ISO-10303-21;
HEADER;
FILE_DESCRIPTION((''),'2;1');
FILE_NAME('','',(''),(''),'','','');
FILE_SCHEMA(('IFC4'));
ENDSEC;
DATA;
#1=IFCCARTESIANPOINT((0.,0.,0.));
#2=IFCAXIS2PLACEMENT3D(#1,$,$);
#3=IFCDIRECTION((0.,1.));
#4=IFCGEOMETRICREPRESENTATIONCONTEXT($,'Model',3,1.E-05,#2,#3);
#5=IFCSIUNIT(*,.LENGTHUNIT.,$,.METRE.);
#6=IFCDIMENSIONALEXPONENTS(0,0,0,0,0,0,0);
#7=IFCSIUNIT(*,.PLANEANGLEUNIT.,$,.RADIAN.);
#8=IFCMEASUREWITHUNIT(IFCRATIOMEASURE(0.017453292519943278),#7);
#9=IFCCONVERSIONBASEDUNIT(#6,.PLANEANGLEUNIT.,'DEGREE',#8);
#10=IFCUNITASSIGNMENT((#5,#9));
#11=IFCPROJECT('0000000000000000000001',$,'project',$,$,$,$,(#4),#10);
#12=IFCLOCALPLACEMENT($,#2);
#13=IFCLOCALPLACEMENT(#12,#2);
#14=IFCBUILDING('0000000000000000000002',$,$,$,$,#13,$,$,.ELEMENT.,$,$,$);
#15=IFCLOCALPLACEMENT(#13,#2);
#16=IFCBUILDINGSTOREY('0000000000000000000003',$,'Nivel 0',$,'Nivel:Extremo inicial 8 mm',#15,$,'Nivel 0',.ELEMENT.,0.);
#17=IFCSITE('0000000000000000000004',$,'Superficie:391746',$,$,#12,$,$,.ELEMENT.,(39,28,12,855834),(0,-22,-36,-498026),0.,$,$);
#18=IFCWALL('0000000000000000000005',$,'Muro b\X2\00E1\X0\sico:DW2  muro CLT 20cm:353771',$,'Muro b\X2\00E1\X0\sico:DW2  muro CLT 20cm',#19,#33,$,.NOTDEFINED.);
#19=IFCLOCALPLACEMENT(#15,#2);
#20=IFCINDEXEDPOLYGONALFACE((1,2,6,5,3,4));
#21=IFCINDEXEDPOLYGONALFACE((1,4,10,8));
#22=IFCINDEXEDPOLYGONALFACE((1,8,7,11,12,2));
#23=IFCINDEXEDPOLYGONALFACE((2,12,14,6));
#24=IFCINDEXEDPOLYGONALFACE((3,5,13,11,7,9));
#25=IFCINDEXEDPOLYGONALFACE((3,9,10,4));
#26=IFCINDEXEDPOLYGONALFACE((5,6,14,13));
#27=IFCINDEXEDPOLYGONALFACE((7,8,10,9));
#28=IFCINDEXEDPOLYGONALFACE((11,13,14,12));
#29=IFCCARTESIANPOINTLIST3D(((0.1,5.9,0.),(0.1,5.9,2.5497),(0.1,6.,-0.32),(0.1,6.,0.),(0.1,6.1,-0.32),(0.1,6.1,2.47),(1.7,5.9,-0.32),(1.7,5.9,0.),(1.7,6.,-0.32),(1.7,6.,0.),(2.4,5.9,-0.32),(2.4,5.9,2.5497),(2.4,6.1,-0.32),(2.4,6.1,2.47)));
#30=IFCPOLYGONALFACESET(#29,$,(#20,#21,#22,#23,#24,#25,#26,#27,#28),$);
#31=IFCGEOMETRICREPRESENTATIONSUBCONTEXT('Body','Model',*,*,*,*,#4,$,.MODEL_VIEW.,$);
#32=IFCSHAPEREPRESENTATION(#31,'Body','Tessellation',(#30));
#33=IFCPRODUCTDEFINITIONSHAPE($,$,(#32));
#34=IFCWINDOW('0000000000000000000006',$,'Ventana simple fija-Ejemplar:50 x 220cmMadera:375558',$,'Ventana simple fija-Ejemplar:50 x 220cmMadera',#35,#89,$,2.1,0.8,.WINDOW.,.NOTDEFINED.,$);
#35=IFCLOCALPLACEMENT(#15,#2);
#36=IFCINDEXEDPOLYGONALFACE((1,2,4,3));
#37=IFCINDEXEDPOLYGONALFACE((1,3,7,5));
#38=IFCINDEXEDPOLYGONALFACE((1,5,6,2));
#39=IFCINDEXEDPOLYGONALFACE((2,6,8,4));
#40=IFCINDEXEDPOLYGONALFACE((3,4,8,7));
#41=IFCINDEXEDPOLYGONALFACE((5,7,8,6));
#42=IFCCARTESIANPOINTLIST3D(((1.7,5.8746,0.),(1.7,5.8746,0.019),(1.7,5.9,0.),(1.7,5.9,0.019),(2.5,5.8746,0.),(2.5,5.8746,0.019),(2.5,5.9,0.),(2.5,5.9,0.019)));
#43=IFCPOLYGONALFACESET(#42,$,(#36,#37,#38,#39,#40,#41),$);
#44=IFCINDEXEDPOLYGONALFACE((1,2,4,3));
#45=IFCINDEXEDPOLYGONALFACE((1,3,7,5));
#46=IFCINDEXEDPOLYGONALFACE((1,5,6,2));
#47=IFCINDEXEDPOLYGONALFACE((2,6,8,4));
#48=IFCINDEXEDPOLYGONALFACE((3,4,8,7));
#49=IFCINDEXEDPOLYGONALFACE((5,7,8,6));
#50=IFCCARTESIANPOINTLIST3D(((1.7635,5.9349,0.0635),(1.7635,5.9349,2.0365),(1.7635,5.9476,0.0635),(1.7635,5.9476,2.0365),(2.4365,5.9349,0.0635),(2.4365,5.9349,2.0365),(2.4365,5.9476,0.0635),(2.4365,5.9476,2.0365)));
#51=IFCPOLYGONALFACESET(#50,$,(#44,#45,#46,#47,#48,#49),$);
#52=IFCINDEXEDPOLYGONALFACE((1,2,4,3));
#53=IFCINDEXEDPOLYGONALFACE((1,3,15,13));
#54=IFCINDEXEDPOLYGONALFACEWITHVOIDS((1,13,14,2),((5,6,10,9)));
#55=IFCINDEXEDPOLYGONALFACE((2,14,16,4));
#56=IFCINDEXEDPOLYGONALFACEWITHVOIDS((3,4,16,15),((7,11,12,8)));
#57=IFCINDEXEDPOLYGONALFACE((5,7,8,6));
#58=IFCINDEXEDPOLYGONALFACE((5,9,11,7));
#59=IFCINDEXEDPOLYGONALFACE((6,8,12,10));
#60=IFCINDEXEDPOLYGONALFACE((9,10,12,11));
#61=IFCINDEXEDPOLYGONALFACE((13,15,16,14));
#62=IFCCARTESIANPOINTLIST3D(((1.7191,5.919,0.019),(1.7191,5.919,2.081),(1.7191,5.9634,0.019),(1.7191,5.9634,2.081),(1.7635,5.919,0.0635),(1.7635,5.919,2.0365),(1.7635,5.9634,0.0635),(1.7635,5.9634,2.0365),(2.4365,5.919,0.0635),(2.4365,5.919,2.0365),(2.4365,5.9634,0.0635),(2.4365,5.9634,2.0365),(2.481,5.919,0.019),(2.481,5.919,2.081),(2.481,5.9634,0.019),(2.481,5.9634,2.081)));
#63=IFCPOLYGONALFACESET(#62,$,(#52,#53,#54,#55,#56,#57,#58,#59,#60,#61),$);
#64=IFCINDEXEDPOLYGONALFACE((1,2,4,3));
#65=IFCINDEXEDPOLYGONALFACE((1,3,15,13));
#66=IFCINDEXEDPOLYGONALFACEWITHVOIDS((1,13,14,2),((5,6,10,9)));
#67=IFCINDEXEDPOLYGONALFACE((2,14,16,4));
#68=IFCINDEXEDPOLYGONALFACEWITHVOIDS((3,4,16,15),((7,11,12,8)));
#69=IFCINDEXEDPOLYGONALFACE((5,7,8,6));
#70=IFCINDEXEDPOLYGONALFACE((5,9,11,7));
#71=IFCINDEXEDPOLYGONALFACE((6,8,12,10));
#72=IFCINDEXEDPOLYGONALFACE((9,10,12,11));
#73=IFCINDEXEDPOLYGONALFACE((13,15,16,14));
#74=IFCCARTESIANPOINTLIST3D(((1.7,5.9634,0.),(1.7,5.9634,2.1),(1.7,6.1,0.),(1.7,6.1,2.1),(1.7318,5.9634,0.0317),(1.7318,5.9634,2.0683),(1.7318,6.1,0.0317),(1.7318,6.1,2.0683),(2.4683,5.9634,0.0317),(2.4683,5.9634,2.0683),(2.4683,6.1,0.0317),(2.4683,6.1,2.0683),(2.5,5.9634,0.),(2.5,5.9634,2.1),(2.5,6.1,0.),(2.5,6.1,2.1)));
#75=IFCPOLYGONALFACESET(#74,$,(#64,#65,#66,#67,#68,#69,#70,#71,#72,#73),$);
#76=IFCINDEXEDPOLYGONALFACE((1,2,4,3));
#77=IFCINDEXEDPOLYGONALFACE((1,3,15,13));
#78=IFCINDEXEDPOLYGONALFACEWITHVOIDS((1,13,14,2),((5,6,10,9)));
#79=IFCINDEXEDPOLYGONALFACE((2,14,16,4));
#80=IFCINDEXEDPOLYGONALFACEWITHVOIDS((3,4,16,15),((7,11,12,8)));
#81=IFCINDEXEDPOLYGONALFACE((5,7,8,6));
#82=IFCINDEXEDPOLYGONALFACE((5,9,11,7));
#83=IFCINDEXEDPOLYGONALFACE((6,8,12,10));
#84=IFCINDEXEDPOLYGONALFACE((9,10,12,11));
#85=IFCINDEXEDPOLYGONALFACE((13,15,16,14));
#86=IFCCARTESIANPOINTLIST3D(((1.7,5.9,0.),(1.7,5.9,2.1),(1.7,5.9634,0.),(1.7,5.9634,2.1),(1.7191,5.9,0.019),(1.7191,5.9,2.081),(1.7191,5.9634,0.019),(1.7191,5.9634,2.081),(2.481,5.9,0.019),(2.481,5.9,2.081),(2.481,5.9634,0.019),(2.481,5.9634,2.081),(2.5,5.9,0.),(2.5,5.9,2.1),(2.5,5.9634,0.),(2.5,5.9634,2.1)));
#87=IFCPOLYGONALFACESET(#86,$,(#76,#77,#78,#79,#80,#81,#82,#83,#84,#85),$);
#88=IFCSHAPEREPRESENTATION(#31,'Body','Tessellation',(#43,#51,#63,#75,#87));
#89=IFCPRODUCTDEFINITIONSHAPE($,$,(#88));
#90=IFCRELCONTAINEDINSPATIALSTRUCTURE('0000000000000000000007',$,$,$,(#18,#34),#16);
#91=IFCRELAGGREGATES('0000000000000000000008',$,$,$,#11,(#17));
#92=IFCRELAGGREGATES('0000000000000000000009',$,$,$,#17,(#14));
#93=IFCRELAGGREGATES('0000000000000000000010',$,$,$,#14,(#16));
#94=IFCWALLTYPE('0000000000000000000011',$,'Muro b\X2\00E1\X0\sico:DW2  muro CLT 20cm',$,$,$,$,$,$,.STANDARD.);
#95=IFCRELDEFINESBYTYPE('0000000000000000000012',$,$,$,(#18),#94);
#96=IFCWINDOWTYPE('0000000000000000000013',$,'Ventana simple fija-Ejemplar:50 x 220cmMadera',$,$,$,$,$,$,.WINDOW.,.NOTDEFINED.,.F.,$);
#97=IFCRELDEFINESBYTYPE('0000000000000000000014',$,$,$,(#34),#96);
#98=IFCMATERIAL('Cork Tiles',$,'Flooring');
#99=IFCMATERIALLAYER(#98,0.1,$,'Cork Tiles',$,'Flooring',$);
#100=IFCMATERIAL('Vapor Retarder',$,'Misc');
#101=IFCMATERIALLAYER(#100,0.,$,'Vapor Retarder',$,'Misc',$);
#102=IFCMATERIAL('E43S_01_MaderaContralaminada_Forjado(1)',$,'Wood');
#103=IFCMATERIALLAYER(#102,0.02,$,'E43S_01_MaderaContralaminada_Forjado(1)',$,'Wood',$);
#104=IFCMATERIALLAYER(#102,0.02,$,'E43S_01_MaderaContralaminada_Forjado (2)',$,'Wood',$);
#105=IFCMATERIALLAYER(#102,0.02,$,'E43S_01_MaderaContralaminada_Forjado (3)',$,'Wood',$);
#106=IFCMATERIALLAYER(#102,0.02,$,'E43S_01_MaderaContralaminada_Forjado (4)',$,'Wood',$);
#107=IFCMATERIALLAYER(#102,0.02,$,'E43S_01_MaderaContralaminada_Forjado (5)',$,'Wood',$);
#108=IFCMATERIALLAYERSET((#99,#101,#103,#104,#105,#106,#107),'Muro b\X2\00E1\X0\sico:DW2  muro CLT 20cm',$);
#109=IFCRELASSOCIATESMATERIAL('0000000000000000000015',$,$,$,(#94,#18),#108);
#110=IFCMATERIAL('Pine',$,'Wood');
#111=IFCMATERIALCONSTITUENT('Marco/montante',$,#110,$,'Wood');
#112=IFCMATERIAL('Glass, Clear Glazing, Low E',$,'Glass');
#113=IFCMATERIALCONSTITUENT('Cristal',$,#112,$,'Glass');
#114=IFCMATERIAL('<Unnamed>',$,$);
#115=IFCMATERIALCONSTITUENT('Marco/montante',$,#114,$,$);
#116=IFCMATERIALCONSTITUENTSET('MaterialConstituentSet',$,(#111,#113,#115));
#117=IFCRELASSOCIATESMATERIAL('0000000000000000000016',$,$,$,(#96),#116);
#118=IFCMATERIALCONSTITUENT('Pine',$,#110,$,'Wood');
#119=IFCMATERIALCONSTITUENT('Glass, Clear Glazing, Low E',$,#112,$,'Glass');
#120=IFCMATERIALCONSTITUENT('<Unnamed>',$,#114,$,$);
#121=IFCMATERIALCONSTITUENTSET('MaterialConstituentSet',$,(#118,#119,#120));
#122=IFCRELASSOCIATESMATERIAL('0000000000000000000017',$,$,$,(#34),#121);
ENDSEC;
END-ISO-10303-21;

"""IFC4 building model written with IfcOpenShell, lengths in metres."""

from ifc_helpers import new_model, entity, si_unit, converted_unit, direction, frame, frame_2d, origin, origin_2d_with_axis, place, context, subcontext, project, spatial, polyline, rectangle, outline, extrude, clip, bounded_halfspace, source, transform, mapped, material, layer, layer_set, layer_usage, constituent, constituent_set, type_object, type_shapes, element, fill, save


model = new_model("IFC4")

# Units and contexts
model_context = context("Model", 3, precision=1e-05, world=origin(), true_north=direction((0.0, 1.0)))
body_context = subcontext(model_context, "Body", "Model", "MODEL_VIEW")
ifc_project = project(units=[si_unit("LENGTHUNIT", "METRE"), converted_unit("PLANEANGLEUNIT", "DEGREE", entity("IfcRatioMeasure", 0.017453292519943278), si_unit("PLANEANGLEUNIT", "RADIAN"), dimensions=[0, 0, 0, 0, 0, 0, 0])], contexts=[model_context])

# Site, building, storey
site_placement = place(None, origin())
site = spatial("IfcSite", under=ifc_project, at=site_placement, Name="Superficie:391746", CompositionType="ELEMENT", RefLatitude=(39, 28, 12, 855834), RefLongitude=(0, -22, -36, -498026), RefElevation=0.0)
building_placement = place(site_placement, origin())
building = spatial("IfcBuilding", under=site, at=building_placement, CompositionType="ELEMENT")
storey_placement = place(building_placement, origin())
storey = spatial("IfcBuildingStorey", under=building, at=storey_placement, Name="Nivel 0", ObjectType="Nivel:Extremo inicial 8 mm", LongName="Nivel 0", CompositionType="ELEMENT", Elevation=0.0)

# Shared definitions
ifc_material_1 = material(Name="E43S_01_MaderaContralaminada_Forjado(1)", Category="Wood")

# Shared definitions
ifc_material_2 = material(Name="Cork Tiles", Category="Flooring")

# Shared definitions
ifc_material_3 = material(Name="Vapor Retarder", Category="Misc")

# Wall, opening, window
ifc_layer_1 = layer(ifc_material_2, 0.1, Name="Cork Tiles", Category="Flooring")
ifc_layer_2 = layer(ifc_material_3, 0.0, Name="Vapor Retarder", Category="Misc")
ifc_layer_3 = layer(ifc_material_1, 0.02, Name="E43S_01_MaderaContralaminada_Forjado(1)", Category="Wood")
ifc_layer_4 = layer(ifc_material_1, 0.02, Name="E43S_01_MaderaContralaminada_Forjado (2)", Category="Wood")
ifc_layer_5 = layer(ifc_material_1, 0.02, Name="E43S_01_MaderaContralaminada_Forjado (3)", Category="Wood")
ifc_layer_6 = layer(ifc_material_1, 0.02, Name="E43S_01_MaderaContralaminada_Forjado (4)", Category="Wood")
ifc_layer_7 = layer(ifc_material_1, 0.02, Name="E43S_01_MaderaContralaminada_Forjado (5)", Category="Wood")
ifc_layer_set_1 = layer_set([ifc_layer_1, ifc_layer_2, ifc_layer_3, ifc_layer_4, ifc_layer_5, ifc_layer_6, ifc_layer_7], Name="Muro básico:DW2  muro CLT 20cm")
ifc_layer_usage_1 = layer_usage(ifc_layer_set_1, "AXIS2", "NEGATIVE", 0.1)
wall_type_1 = type_object("IfcWallType", Name="Muro básico:DW2  muro CLT 20cm", PredefinedType="STANDARD", material=ifc_layer_set_1)
wall_1_placement = place(storey_placement, frame((0.1, 6.0, -0.32)))
wall_1 = element("IfcWall", 1, at=wall_1_placement, inside=storey, type_object=wall_type_1, material=ifc_layer_usage_1, Name="Muro básico:DW2  muro CLT 20cm:353771", ObjectType="Muro básico:DW2  muro CLT 20cm", PredefinedType="NOTDEFINED", context=body_context, shape_type="Clipping", body=[
    clip(clip(extrude(rectangle(XDim=0.2, YDim=2.3, at=frame_2d((1.15, 0.0), x_axis=(0.0, -1.0))), origin(), (0.0, 0.0, 1.0), 2.8697), bounded_halfspace(frame((0.0, 0.1, 2.79), z_axis=(0.0, 0.370288, 0.928917), x_axis=(-1.0, 0.0, 0.0)), False, frame((0.0, 0.1, 2.79)), polyline([(0.0, 0.0), (0.0, -0.2), (2.3, -0.2), (2.3, 0.0), (0.0, 0.0)]))), bounded_halfspace(frame((0.0, -0.1, 0.32), z_axis=(0.0, 0.0, -1.0), x_axis=(0.0, 1.0, 0.0)), False, frame((0.0, -0.1, 0.32)), polyline([(0.0, 0.0), (1.6, 0.0), (1.6, 0.1), (0.0, 0.1), (0.0, 0.0)]))),
])
opening_1_placement = place(wall_1_placement, frame((2.4, 0.1, 0.32)))
opening_1 = element("IfcOpeningElement", 2, at=opening_1_placement, cuts=wall_1, PredefinedType="OPENING", context=body_context, shape_type="SweptSolid", body=[
    extrude(rectangle(XDim=2.1, YDim=0.8, at=frame_2d((1.05, 0.4), x_axis=(-1.0, 0.0))), frame((0.0, 0.0, 0.0), z_axis=(0.0, -1.0, 0.0), x_axis=(0.0, 0.0, 1.0)), (0.0, 0.0, 1.0), 0.2),
])
ifc_material_4 = material(Name="Pine", Category="Wood")
ifc_constituent_1 = constituent(ifc_material_4, Name="Pine", Category="Wood")
ifc_material_5 = material(Name="Glass, Clear Glazing, Low E", Category="Glass")
ifc_constituent_2 = constituent(ifc_material_5, Name="Glass, Clear Glazing, Low E", Category="Glass")
ifc_material_6 = material(Name="<Unnamed>")
ifc_constituent_3 = constituent(ifc_material_6, Name="<Unnamed>")
ifc_constituent_set_1 = constituent_set(constituents=[ifc_constituent_1, ifc_constituent_2, ifc_constituent_3], Name="MaterialConstituentSet")
ifc_constituent_4 = constituent(ifc_material_4, Name="Marco/montante", Category="Wood")
ifc_constituent_5 = constituent(ifc_material_5, Name="Cristal", Category="Glass")
ifc_constituent_6 = constituent(ifc_material_6, Name="Marco/montante")
ifc_constituent_set_2 = constituent_set(constituents=[ifc_constituent_4, ifc_constituent_5, ifc_constituent_6], Name="MaterialConstituentSet")
window_type_1 = type_object("IfcWindowType", Name="Ventana simple fija-Ejemplar:50 x 220cmMadera", ParameterTakesPrecedence=False, PartitioningType="NOTDEFINED", PredefinedType="WINDOW", material=ifc_constituent_set_2)
shared_shape_1 = source(origin(), body_context, "Body", "SweptSolid", [
    extrude(rectangle(XDim=0.8, YDim=0.0254, at=origin_2d_with_axis()), frame((0.4762, 0.2127, 0.0), z_axis=(0.0, 0.0, 1.0), x_axis=(-1.0, 0.0, 0.0)), (0.0, 0.0, 1.0), 0.019),
    extrude(rectangle(XDim=0.673, YDim=0.0127, at=frame_2d((0.0, 0.0), x_axis=(1.0, 0.0))), frame((0.4762, 0.1588, 0.0635)), (0.0, 0.0, 1.0), 1.973),
    extrude(outline(polyline([(-0.3809, -1.031), (0.3809, -1.031), (0.3809, 1.031), (-0.3809, 1.031), (-0.3809, -1.031)]), holes=[polyline([(-0.3365, -0.9865), (-0.3365, 0.9865), (0.3365, 0.9865), (0.3365, -0.9865), (-0.3365, -0.9865)])]), frame((0.4762, 0.181, 1.05), z_axis=(0.0, -1.0, 0.0), x_axis=(-1.0, 0.0, 0.0)), (0.0, 0.0, 1.0), 0.0444),
    extrude(outline(polyline([(-0.4, -1.05), (0.4, -1.05), (0.4, 1.05), (-0.4, 1.05), (-0.4, -1.05)]), holes=[polyline([(-0.3683, -1.0183), (-0.3683, 1.0183), (0.3682, 1.0183), (0.3682, -1.0183), (-0.3683, -1.0183)])]), frame((0.4762, 0.1365, 1.05), z_axis=(0.0, -1.0, 0.0), x_axis=(-1.0, 0.0, 0.0)), (0.0, 0.0, 1.0), 0.1365),
    extrude(outline(polyline([(-1.05, -0.4), (1.05, -0.4), (1.05, 0.4), (-1.05, 0.4), (-1.05, -0.4)]), holes=[polyline([(-1.031, -0.3809), (-1.031, 0.381), (1.031, 0.381), (1.031, -0.3809), (-1.031, -0.3809)])]), frame((0.4762, 0.2, 1.05), z_axis=(0.0, -1.0, 0.0), x_axis=(0.0, 0.0, -1.0)), (0.0, 0.0, 1.0), 0.0635),
])
type_shapes(window_type_1, [shared_shape_1])
window_1_placement = place(opening_1_placement, frame((0.0762, 0.0, 0.0), z_axis=(0.0, 0.0, 1.0), x_axis=(-1.0, 0.0, 0.0)))
window_1 = element("IfcWindow", 3, at=window_1_placement, inside=storey, type_object=window_type_1, material=ifc_constituent_set_1, Name="Ventana simple fija-Ejemplar:50 x 220cmMadera:375558", ObjectType="Ventana simple fija-Ejemplar:50 x 220cmMadera", OverallHeight=2.1, OverallWidth=0.8, PartitioningType="NOTDEFINED", PredefinedType="WINDOW", context=body_context, shape_type="MappedRepresentation", body=[
    mapped(shared_shape_1, transform((0.0, 0.0, 0.0), scale=1.0)),
])
fill(opening_1, window_1)

save(model, "model.ifc")
